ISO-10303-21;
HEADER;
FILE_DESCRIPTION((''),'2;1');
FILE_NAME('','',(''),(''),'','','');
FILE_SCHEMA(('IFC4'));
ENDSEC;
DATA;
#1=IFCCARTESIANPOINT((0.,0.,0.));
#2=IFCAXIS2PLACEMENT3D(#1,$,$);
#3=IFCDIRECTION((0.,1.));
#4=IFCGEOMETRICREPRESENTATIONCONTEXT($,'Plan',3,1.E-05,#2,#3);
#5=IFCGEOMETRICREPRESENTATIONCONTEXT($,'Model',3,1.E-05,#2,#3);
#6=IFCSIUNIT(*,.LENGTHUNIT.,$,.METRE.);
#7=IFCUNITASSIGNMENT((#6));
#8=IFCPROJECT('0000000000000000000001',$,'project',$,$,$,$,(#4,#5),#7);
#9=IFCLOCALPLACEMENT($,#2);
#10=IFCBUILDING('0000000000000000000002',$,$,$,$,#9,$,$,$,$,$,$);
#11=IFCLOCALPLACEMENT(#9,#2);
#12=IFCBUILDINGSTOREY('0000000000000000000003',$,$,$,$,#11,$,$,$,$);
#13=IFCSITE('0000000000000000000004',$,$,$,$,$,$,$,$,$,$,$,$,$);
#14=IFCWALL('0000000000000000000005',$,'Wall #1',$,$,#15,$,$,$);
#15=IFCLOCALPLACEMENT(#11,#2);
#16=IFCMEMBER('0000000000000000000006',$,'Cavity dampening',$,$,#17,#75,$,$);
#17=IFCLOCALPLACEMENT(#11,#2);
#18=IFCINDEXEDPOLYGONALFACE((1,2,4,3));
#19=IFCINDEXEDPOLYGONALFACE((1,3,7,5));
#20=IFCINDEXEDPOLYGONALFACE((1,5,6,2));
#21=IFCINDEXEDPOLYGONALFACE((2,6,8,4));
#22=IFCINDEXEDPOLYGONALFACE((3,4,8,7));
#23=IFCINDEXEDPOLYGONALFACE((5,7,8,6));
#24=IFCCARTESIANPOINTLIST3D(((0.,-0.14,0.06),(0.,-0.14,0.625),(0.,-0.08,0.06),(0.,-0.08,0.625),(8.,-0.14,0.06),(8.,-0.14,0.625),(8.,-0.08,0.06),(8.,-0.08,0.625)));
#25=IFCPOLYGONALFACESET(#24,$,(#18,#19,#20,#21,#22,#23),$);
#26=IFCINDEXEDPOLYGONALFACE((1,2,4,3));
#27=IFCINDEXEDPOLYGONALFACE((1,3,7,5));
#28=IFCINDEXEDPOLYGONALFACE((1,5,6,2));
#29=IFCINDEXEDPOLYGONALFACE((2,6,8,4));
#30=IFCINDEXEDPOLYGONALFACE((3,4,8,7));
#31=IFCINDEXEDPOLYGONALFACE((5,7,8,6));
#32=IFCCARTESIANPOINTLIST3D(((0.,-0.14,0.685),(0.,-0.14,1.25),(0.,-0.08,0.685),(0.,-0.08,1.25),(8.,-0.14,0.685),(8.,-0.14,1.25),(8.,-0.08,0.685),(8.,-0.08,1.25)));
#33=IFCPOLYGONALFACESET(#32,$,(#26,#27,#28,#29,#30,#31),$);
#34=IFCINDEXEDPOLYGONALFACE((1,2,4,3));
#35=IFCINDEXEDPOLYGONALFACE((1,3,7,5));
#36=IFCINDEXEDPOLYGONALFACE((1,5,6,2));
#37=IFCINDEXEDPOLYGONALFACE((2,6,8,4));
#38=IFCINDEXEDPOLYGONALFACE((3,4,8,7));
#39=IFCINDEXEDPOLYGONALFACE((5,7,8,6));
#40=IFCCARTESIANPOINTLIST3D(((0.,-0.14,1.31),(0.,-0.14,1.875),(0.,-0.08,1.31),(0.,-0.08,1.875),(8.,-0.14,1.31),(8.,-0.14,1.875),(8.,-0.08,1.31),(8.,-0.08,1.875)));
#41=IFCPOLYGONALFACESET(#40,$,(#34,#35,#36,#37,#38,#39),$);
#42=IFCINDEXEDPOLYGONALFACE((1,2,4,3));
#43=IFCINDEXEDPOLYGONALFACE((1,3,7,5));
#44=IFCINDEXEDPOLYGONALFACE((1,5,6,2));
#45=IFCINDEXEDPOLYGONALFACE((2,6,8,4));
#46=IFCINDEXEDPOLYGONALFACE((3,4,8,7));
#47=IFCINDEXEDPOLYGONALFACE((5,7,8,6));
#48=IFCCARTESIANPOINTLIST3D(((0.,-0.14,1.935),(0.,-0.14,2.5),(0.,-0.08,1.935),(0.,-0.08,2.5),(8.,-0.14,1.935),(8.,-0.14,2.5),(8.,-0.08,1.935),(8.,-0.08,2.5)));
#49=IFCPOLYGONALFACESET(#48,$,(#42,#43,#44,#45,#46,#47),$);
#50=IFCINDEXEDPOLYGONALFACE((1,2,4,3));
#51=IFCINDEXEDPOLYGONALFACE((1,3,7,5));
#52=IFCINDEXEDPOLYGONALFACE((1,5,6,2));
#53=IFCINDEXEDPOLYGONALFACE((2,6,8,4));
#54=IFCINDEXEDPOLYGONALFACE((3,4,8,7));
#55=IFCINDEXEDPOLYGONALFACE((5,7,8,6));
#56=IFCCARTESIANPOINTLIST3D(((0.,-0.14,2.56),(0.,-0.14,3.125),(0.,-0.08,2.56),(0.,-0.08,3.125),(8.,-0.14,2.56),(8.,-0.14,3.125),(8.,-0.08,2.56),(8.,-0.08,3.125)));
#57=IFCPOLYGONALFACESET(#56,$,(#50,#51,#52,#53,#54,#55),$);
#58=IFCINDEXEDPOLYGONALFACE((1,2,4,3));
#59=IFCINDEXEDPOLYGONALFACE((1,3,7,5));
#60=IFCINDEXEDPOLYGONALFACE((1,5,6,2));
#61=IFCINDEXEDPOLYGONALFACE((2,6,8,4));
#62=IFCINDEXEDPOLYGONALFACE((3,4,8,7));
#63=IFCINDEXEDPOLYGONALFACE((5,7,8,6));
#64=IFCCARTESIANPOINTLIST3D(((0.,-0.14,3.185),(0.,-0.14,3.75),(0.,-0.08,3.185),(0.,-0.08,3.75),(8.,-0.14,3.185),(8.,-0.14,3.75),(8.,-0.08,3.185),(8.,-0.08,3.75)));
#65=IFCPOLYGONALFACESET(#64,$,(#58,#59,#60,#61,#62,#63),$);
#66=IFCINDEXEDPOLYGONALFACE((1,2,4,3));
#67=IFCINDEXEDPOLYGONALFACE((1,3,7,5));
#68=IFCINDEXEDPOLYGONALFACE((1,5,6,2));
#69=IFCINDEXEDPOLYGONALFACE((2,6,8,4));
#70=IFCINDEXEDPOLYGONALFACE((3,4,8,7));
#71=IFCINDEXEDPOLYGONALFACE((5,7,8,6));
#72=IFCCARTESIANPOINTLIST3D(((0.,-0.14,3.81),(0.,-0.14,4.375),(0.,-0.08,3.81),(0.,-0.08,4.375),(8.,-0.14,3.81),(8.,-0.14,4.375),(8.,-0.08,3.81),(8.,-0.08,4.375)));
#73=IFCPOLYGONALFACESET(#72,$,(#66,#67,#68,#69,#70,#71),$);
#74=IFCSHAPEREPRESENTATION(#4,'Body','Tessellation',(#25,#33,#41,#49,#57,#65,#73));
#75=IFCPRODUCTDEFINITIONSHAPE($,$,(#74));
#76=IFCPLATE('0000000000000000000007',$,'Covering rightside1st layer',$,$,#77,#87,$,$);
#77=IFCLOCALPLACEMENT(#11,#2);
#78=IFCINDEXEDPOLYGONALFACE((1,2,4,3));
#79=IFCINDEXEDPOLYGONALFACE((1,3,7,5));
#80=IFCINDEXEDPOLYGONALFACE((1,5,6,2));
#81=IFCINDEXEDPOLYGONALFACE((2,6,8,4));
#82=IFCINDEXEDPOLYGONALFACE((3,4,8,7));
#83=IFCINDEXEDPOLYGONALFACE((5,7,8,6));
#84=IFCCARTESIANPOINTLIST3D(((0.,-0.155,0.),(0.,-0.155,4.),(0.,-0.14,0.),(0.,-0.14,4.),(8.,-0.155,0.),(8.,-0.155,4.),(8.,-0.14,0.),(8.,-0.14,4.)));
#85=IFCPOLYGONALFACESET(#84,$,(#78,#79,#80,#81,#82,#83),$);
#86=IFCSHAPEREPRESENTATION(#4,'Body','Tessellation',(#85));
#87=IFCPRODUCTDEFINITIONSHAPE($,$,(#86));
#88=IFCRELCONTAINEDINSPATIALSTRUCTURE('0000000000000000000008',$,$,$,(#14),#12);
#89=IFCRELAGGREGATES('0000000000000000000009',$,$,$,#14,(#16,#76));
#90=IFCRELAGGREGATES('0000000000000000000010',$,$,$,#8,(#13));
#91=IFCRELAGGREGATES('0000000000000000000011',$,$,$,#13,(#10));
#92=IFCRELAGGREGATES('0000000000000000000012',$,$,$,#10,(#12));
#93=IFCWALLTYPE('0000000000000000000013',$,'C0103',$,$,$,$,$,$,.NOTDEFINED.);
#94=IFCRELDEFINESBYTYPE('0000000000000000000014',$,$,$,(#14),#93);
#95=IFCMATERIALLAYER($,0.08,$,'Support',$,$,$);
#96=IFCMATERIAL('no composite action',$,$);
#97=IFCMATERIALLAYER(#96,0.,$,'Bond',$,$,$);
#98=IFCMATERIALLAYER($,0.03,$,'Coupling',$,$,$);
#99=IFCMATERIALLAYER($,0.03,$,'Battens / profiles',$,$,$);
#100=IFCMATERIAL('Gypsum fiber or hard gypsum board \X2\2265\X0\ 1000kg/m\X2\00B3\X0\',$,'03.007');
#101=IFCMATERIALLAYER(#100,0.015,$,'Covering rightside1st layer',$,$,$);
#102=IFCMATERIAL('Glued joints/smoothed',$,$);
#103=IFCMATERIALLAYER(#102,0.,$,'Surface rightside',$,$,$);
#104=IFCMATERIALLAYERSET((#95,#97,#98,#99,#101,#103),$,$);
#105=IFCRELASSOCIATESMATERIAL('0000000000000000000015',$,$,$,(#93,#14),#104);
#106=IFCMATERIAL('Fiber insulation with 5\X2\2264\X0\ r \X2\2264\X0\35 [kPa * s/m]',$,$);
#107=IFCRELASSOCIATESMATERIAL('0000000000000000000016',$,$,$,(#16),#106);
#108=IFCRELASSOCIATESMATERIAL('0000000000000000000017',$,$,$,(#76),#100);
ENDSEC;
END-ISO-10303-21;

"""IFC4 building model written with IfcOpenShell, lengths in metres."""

from ifc_helpers import new_model, si_unit, direction, frame, frame_2d, origin, place, context, project, spatial, rectangle, extrude, material, layer, layer_set, type_object, element, aggregate, save


model = new_model("IFC4")

# Units and contexts
plan_context = context("Plan", 3, precision=1e-05, world=origin(), true_north=direction((0.0, 1.0)))
model_context = context("Model", 3, precision=1e-05, world=origin(), true_north=direction((0.0, 1.0)))
ifc_project = project(units=[si_unit("LENGTHUNIT", "METRE")], contexts=[plan_context, model_context])

# Site, building, storey
site = spatial("IfcSite", under=ifc_project)
building_placement = place(None, origin())
building = spatial("IfcBuilding", under=site, at=building_placement)
storey_placement = place(building_placement, origin())
storey = spatial("IfcBuildingStorey", under=building, at=storey_placement)

# Wall, member, plate
ifc_layer_1 = layer(None, 0.08, Name="Support")
ifc_material_1 = material(Name="no composite action")
ifc_layer_2 = layer(ifc_material_1, 0.0, Name="Bond")
ifc_layer_3 = layer(None, 0.03, Name="Coupling")
ifc_layer_4 = layer(None, 0.03, Name="Battens / profiles")
ifc_material_2 = material(Name="Gypsum fiber or hard gypsum board ≥ 1000kg/m³", Category="03.007")
ifc_layer_5 = layer(ifc_material_2, 0.015, Name="Covering rightside1st layer")
ifc_material_3 = material(Name="Glued joints/smoothed")
ifc_layer_6 = layer(ifc_material_3, 0.0, Name="Surface rightside")
ifc_layer_set = layer_set([ifc_layer_1, ifc_layer_2, ifc_layer_3, ifc_layer_4, ifc_layer_5, ifc_layer_6])
wall_type = type_object("IfcWallType", Name="C0103", PredefinedType="NOTDEFINED", material=ifc_layer_set)
wall_placement = place(None, frame((0.0, 0.0, 0.0), z_axis=(0.0, -1.0, 0.0), x_axis=(1.0, 0.0, 0.0)))
wall = element("IfcWall", 1, at=wall_placement, inside=storey, type_object=wall_type, material=ifc_layer_set, Name="Wall #1")
ifc_material_4 = material(Name="Fiber insulation with 5≤ r ≤35 [kPa * s/m]")
member_1_placement = place(wall_placement, origin())
member_1 = element("IfcMember", 2, at=member_1_placement, material=ifc_material_4, Name="Cavity dampening", context=plan_context, shape_type="SweptSolid", body=[
    extrude(rectangle(XDim=0.565, YDim=0.06, at=frame_2d((0.2825, 0.03), x_axis=(1.0, 0.0))), frame((0.0, 0.06, 0.08), z_axis=(1.0, 0.0, 0.0), x_axis=(0.0, 1.0, 0.0)), (0.0, 0.0, 1.0), 8.0),
    extrude(rectangle(XDim=0.565, YDim=0.06, at=frame_2d((0.2825, 0.03), x_axis=(1.0, 0.0))), frame((0.0, 0.685, 0.08), z_axis=(1.0, 0.0, 0.0), x_axis=(0.0, 1.0, 0.0)), (0.0, 0.0, 1.0), 8.0),
    extrude(rectangle(XDim=0.565, YDim=0.06, at=frame_2d((0.2825, 0.03), x_axis=(1.0, 0.0))), frame((0.0, 1.31, 0.08), z_axis=(1.0, 0.0, 0.0), x_axis=(0.0, 1.0, 0.0)), (0.0, 0.0, 1.0), 8.0),
    extrude(rectangle(XDim=0.565, YDim=0.06, at=frame_2d((0.2825, 0.03), x_axis=(1.0, 0.0))), frame((0.0, 1.935, 0.08), z_axis=(1.0, 0.0, 0.0), x_axis=(0.0, 1.0, 0.0)), (0.0, 0.0, 1.0), 8.0),
    extrude(rectangle(XDim=0.565, YDim=0.06, at=frame_2d((0.2825, 0.03), x_axis=(1.0, 0.0))), frame((0.0, 2.56, 0.08), z_axis=(1.0, 0.0, 0.0), x_axis=(0.0, 1.0, 0.0)), (0.0, 0.0, 1.0), 8.0),
    extrude(rectangle(XDim=0.565, YDim=0.06, at=frame_2d((0.2825, 0.03), x_axis=(1.0, 0.0))), frame((0.0, 3.185, 0.08), z_axis=(1.0, 0.0, 0.0), x_axis=(0.0, 1.0, 0.0)), (0.0, 0.0, 1.0), 8.0),
    extrude(rectangle(XDim=0.565, YDim=0.06, at=frame_2d((0.2825, 0.03), x_axis=(1.0, 0.0))), frame((0.0, 3.81, 0.08), z_axis=(1.0, 0.0, 0.0), x_axis=(0.0, 1.0, 0.0)), (0.0, 0.0, 1.0), 8.0),
])
plate_placement = place(wall_placement, origin())
plate = element("IfcPlate", 3, at=plate_placement, material=ifc_material_2, Name="Covering rightside1st layer", context=plan_context, shape_type="SweptSolid", body=[
    extrude(rectangle(XDim=8.0, YDim=4.0, at=frame_2d((4.0, 2.0), x_axis=(1.0, 0.0))), frame((0.0, 0.0, 0.14), z_axis=(0.0, 0.0, 1.0), x_axis=(1.0, 0.0, 0.0)), (0.0, 0.0, 1.0), 0.015),
])
aggregate(wall, [member_1, plate])

save(model, "model.ifc")
